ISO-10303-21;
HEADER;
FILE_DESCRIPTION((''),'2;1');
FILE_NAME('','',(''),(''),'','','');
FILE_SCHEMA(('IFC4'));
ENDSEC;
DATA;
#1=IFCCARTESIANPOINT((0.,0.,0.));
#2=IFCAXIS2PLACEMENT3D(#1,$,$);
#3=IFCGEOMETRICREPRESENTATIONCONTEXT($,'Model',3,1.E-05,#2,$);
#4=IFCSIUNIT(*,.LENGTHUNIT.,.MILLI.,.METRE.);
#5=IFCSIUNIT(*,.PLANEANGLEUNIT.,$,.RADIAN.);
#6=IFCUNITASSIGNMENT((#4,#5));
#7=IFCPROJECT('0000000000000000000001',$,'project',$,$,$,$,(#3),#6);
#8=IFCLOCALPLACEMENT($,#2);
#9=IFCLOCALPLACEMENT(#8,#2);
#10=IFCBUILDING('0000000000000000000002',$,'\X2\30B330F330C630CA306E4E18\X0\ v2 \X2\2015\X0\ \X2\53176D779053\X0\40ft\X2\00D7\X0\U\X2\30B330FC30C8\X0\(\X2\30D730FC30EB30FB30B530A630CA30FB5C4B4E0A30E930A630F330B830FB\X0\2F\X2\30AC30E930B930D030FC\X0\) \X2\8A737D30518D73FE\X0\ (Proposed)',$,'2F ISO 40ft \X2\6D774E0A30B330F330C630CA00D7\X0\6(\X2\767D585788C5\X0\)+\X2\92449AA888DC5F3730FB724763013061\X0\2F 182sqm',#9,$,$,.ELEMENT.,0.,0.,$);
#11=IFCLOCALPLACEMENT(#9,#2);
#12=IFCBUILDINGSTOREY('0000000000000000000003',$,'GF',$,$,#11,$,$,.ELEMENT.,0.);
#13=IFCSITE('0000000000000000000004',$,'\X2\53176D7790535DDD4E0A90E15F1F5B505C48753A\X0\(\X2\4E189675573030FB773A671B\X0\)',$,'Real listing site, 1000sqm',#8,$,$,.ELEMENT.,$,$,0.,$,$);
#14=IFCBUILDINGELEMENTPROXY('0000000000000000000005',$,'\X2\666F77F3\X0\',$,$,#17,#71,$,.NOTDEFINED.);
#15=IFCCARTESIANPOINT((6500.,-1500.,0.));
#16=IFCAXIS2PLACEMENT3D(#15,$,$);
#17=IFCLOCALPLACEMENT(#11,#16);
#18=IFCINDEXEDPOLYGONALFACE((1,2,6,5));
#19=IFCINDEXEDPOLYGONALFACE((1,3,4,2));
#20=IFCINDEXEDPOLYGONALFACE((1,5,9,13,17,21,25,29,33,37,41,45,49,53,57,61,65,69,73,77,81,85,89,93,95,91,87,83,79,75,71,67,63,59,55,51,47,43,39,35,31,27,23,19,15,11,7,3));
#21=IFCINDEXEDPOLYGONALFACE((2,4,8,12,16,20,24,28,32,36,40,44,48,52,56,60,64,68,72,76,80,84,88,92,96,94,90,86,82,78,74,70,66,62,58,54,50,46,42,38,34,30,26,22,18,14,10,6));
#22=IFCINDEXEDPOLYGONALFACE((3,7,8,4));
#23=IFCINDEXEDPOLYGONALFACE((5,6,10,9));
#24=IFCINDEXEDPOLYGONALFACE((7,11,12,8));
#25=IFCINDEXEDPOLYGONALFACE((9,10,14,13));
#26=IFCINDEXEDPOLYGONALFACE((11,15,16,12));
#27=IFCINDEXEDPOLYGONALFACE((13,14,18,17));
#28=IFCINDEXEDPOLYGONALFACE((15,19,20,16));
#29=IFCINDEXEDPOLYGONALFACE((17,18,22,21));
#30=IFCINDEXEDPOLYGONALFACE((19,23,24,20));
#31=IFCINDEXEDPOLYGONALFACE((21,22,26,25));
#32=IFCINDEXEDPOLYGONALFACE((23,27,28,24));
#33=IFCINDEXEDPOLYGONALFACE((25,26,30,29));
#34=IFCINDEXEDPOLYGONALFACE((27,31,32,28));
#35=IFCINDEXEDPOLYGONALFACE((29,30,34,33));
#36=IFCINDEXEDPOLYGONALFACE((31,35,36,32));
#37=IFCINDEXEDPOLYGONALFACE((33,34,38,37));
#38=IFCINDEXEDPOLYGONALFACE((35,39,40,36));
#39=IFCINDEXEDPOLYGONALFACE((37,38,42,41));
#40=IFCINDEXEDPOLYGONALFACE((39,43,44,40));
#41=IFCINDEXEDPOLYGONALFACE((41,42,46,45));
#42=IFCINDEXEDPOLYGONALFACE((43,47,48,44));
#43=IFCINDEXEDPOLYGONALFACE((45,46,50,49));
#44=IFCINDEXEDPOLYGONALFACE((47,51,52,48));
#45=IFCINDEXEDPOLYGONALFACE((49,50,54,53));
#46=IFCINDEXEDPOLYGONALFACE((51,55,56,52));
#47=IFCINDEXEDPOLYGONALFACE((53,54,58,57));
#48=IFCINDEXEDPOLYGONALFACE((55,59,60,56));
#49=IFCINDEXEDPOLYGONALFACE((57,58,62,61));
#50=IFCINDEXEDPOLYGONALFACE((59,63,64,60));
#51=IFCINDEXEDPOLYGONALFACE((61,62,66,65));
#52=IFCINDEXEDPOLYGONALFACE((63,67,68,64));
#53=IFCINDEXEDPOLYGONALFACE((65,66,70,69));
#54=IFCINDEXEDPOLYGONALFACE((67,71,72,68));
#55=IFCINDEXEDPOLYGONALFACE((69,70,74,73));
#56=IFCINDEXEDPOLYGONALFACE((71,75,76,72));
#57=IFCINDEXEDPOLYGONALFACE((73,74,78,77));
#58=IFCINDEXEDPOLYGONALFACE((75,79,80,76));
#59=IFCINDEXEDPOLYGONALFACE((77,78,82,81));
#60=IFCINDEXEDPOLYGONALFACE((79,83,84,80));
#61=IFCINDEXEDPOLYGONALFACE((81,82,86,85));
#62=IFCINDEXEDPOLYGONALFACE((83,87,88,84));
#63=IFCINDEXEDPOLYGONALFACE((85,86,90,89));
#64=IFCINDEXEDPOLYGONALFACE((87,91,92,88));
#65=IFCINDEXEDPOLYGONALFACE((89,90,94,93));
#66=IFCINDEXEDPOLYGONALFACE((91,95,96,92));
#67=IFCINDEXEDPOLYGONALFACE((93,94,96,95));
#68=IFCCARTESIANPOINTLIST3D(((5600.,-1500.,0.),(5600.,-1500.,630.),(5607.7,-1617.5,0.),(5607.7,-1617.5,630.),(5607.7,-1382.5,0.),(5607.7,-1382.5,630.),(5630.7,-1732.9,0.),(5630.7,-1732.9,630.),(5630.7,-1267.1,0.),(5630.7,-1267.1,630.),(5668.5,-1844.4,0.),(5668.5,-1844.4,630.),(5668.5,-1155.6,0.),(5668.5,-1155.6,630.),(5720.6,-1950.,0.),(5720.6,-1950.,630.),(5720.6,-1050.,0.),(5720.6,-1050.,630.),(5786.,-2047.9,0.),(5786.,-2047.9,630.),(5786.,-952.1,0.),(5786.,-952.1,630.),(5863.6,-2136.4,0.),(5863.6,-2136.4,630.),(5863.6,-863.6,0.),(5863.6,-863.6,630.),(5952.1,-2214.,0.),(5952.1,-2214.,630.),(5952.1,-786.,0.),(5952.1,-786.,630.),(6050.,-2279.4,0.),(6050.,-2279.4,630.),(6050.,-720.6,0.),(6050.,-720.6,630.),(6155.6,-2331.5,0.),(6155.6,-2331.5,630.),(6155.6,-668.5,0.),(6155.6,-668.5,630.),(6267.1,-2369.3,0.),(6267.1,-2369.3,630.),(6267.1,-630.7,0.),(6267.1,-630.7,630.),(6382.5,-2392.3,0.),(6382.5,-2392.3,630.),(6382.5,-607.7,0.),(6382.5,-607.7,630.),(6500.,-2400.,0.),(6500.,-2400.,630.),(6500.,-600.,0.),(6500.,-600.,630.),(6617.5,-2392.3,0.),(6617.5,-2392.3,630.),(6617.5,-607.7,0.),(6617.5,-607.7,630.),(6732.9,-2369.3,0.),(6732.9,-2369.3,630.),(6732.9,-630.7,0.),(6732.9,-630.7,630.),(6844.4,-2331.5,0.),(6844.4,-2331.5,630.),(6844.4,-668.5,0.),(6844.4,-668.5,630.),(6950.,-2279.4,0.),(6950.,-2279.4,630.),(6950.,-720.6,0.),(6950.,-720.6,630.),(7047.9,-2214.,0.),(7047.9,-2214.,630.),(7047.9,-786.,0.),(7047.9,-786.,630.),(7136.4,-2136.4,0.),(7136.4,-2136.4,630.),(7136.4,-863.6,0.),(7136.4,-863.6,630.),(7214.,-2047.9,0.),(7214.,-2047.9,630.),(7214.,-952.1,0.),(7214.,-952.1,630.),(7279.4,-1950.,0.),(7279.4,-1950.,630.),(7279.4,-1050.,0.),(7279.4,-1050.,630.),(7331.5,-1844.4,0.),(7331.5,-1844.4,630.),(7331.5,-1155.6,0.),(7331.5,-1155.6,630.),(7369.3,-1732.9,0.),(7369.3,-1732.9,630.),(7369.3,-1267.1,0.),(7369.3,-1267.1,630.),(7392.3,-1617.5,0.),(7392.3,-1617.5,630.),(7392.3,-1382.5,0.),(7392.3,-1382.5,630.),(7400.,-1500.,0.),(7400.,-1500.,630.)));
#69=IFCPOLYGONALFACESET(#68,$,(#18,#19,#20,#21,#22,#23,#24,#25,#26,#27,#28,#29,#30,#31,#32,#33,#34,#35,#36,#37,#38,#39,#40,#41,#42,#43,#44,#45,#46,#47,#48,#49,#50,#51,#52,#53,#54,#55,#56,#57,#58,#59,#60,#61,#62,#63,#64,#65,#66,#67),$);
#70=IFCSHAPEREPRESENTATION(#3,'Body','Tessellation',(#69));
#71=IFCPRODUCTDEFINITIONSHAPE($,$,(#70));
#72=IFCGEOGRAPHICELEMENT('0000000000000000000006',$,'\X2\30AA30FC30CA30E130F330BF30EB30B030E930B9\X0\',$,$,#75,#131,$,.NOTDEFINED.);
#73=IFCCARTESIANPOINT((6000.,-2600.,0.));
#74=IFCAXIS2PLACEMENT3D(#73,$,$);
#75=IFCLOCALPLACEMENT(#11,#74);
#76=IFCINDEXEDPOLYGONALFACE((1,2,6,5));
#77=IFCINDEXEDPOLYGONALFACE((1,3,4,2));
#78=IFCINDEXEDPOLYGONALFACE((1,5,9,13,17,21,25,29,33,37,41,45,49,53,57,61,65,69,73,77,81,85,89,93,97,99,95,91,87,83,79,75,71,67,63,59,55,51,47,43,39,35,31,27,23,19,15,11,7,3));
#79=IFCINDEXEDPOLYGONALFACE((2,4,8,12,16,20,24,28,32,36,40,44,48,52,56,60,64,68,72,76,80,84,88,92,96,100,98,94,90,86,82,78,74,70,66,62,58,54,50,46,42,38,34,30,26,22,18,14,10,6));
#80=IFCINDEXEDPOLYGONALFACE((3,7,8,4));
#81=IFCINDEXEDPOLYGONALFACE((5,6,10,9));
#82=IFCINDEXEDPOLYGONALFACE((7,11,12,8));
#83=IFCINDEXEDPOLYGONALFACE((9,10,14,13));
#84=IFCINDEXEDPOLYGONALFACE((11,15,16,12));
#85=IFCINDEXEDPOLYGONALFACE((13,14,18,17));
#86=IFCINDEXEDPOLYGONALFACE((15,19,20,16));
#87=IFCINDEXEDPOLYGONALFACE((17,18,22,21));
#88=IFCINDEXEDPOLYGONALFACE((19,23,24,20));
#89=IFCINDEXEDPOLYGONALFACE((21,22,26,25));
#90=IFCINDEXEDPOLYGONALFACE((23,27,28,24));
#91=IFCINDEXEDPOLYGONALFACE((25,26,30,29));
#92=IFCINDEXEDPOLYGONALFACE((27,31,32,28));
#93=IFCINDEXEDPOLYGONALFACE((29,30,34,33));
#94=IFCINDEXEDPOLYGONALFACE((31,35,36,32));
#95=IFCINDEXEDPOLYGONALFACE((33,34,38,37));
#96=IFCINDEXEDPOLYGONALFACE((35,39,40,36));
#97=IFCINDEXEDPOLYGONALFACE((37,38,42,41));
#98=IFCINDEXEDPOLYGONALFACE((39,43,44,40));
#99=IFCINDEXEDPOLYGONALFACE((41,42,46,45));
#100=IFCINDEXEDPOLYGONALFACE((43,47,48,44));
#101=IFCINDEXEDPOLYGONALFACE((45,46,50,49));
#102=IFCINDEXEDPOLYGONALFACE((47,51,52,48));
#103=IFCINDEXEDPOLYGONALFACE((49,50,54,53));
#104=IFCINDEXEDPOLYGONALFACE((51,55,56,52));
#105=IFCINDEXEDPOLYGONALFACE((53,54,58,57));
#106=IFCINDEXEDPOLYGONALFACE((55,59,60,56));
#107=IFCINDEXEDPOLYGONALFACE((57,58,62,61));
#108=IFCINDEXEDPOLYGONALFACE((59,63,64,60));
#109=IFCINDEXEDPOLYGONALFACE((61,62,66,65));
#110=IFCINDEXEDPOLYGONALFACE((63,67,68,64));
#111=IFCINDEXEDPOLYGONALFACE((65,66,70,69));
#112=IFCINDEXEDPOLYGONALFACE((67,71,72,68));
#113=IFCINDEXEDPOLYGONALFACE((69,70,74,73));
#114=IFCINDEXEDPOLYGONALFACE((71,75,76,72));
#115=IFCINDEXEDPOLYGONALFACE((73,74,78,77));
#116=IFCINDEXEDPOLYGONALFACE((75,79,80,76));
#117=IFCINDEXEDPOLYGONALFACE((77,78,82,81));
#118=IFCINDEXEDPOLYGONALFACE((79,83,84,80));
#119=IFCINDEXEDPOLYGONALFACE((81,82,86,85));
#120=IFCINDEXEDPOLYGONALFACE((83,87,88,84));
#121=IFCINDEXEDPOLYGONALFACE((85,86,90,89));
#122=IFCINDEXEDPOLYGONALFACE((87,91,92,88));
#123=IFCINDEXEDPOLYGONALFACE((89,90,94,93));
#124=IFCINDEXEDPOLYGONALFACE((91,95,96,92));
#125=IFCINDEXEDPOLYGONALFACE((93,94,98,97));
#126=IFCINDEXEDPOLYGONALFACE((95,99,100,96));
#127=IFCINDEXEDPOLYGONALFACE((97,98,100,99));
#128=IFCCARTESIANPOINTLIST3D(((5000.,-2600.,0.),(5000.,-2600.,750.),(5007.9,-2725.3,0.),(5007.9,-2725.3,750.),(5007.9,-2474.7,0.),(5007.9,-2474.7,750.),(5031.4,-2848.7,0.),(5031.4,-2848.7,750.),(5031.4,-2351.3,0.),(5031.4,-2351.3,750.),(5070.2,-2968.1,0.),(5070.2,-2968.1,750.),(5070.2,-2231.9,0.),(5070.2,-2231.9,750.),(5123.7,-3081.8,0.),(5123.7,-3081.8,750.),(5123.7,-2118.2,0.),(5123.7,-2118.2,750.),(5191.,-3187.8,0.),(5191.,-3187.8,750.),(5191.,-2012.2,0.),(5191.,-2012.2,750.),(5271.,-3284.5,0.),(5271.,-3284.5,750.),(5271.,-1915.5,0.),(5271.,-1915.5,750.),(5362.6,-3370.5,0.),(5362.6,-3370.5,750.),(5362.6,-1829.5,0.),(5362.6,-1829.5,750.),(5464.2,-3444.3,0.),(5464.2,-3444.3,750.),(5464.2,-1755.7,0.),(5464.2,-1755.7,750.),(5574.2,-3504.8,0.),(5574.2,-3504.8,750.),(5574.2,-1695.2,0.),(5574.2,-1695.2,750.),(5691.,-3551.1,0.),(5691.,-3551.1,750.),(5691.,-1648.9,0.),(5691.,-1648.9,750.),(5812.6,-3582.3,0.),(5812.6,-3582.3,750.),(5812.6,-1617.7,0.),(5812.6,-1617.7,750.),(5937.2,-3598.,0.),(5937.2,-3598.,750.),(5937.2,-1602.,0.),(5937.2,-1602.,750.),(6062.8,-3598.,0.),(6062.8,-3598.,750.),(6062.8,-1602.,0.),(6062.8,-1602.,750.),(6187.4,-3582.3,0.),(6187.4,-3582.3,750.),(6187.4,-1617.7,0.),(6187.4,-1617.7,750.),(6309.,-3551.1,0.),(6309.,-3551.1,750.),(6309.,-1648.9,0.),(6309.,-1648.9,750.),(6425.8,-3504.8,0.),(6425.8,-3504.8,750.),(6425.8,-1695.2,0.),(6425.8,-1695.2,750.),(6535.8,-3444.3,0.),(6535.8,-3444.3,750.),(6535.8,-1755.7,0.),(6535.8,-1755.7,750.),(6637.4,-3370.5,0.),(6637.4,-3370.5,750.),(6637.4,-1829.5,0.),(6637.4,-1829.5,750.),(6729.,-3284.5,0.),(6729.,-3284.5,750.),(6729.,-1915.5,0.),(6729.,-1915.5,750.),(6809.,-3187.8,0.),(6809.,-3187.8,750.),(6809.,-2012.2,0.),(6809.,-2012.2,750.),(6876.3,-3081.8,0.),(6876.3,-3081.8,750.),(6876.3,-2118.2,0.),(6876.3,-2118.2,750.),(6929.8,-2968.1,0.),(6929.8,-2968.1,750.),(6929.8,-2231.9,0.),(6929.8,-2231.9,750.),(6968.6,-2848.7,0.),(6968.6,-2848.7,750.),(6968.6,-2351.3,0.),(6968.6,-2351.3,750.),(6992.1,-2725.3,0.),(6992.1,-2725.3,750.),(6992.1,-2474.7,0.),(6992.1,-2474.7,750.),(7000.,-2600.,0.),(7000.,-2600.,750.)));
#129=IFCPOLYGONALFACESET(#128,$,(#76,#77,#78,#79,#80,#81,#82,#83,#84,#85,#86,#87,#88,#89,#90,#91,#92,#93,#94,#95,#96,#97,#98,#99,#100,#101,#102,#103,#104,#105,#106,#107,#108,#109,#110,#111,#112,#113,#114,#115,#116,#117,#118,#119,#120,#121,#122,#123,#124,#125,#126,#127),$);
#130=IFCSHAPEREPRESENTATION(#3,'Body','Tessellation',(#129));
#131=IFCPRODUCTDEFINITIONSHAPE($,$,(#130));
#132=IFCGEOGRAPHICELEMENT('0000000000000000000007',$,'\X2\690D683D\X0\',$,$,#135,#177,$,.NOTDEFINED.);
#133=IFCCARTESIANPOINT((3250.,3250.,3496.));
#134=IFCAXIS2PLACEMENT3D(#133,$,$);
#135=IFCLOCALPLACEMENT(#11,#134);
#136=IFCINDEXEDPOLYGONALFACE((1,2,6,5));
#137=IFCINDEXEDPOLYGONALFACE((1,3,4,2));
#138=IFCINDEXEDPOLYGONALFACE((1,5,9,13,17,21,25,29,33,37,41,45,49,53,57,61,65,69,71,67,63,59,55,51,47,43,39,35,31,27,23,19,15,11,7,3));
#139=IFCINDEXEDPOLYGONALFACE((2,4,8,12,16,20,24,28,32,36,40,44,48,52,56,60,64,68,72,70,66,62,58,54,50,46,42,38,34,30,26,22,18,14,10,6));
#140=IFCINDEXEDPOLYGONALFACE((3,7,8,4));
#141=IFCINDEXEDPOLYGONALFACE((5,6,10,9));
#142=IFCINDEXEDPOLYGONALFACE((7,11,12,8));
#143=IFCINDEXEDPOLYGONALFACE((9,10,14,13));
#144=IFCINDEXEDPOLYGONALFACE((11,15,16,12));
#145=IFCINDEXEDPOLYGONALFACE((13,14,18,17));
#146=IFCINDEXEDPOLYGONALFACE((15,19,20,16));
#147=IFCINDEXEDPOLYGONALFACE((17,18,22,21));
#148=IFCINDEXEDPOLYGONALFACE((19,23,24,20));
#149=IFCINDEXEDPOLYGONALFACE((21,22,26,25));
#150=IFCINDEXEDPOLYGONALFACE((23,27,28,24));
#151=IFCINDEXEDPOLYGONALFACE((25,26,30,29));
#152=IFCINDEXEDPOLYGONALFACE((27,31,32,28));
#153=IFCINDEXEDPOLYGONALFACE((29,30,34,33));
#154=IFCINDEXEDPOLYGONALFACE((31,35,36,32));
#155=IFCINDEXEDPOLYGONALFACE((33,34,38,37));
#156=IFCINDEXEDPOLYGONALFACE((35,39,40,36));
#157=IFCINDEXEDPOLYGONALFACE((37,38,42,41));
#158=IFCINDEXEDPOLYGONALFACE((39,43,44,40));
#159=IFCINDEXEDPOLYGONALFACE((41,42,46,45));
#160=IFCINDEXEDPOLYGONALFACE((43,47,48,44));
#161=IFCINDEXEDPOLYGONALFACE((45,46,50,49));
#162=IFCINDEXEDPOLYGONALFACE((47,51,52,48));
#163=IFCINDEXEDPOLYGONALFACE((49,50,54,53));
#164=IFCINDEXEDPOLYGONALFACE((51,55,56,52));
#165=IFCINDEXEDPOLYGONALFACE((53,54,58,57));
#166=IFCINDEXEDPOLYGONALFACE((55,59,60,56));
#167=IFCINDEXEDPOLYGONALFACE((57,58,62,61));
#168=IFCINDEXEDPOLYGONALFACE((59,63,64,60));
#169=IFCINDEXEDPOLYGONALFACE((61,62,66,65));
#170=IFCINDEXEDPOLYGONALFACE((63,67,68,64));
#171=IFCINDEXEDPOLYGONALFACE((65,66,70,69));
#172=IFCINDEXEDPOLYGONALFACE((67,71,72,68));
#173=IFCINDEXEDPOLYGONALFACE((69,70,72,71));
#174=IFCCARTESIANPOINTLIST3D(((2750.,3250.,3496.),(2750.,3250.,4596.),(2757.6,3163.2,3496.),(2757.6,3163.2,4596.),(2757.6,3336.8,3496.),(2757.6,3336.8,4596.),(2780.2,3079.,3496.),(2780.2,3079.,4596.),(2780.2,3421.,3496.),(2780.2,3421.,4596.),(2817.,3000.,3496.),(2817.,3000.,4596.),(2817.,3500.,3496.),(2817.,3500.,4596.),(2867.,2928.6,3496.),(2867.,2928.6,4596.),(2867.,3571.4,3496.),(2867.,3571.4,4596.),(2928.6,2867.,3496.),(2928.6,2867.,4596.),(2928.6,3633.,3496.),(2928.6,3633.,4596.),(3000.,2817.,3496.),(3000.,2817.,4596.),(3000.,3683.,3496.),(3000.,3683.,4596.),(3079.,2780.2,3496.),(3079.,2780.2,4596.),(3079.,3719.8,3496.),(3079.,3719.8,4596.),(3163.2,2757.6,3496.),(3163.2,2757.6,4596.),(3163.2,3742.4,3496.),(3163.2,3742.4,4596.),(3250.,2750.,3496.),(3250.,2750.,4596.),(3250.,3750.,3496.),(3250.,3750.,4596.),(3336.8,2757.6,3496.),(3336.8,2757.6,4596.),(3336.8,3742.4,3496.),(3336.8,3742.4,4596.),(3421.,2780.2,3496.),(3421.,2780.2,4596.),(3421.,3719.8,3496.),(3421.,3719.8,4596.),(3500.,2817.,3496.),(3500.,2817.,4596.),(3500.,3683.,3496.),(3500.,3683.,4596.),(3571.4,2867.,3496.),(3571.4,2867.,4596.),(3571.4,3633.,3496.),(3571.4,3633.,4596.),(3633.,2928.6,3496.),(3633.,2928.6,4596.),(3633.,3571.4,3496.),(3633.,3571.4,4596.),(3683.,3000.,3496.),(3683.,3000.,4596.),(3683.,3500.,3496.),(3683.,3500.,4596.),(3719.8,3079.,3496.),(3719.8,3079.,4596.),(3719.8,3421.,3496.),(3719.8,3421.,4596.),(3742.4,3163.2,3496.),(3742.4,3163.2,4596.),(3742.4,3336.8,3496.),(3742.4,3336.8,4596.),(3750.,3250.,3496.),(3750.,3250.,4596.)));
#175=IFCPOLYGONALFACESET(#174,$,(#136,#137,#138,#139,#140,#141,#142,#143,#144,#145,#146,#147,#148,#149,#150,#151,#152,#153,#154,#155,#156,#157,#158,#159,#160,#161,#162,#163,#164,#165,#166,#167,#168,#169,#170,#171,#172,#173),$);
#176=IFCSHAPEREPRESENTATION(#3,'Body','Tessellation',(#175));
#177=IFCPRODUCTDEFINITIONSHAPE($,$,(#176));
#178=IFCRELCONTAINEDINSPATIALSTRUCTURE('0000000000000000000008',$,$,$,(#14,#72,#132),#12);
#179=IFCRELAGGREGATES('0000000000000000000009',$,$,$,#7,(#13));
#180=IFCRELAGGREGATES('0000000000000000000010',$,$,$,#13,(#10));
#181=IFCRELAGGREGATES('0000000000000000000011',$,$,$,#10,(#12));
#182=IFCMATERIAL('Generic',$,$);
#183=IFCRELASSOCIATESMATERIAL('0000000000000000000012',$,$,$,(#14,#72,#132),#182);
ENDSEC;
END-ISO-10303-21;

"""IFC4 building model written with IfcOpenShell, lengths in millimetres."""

from ifc_helpers import new_model, si_unit, frame, origin, origin_2d, place, context, project, spatial, circle, extrude, material, element, save


model = new_model("IFC4")

# Units and contexts
model_context = context("Model", 3, precision=1e-05, world=origin())
ifc_project = project(units=[si_unit("LENGTHUNIT", "METRE", prefix="MILLI"), si_unit("PLANEANGLEUNIT", "RADIAN")], contexts=[model_context])

# Site, building, storey
site_placement = place(None, origin())
site = spatial("IfcSite", under=ifc_project, at=site_placement, Name="北海道川上郡弟子屈町(丘陵地・眺望)", ObjectType="Real listing site, 1000sqm", CompositionType="ELEMENT", RefElevation=0.0)
building_placement = place(site_placement, origin())
building = spatial("IfcBuilding", under=site, at=building_placement, Name="コンテナの丘 v2 ― 北海道40ft×Uコート(プール・サウナ・屋上ラウンジ・2Fガラスバー) 詳細再現 (Proposed)", ObjectType="2F ISO 40ft 海上コンテナ×6(白塗装)+鉄骨補強・片持ち2F 182sqm", CompositionType="ELEMENT", ElevationOfRefHeight=0.0, ElevationOfTerrain=0.0)
storey_placement = place(building_placement, origin())
storey = spatial("IfcBuildingStorey", under=building, at=storey_placement, Name="GF", CompositionType="ELEMENT", Elevation=0.0)

# Shared definitions
ifc_material = material(Name="Generic")

# Building element proxy
proxy_1_placement = place(storey_placement, frame((6500.0, -1500.0, 0.0)))
element("IfcBuildingElementProxy", 1, at=proxy_1_placement, inside=storey, material=ifc_material, Name="景石", PredefinedType="NOTDEFINED", context=model_context, shape_type="SweptSolid", body=[
    extrude(circle(Radius=900.0, at=origin_2d()), frame((6500.0, -1500.0, 0.0)), (0.0, 0.0, 1.0), 630.0),
])

# Geographic elements
geographic_element_1_placement = place(storey_placement, frame((6000.0, -2600.0, 0.0)))
element("IfcGeographicElement", 2, at=geographic_element_1_placement, inside=storey, material=ifc_material, Name="オーナメンタルグラス", PredefinedType="NOTDEFINED", context=model_context, shape_type="SweptSolid", body=[
    extrude(circle(Radius=1000.0, at=origin_2d()), frame((6000.0, -2600.0, 0.0)), (0.0, 0.0, 1.0), 750.0),
])
geographic_element_2_placement = place(storey_placement, frame((3250.0, 3250.0, 3496.0)))
element("IfcGeographicElement", 3, at=geographic_element_2_placement, inside=storey, material=ifc_material, Name="植栽", PredefinedType="NOTDEFINED", context=model_context, shape_type="SweptSolid", body=[
    extrude(circle(Radius=500.0, at=origin_2d()), frame((3250.0, 3250.0, 3496.0)), (0.0, 0.0, 1.0), 1100.0),
])

save(model, "model.ifc")
